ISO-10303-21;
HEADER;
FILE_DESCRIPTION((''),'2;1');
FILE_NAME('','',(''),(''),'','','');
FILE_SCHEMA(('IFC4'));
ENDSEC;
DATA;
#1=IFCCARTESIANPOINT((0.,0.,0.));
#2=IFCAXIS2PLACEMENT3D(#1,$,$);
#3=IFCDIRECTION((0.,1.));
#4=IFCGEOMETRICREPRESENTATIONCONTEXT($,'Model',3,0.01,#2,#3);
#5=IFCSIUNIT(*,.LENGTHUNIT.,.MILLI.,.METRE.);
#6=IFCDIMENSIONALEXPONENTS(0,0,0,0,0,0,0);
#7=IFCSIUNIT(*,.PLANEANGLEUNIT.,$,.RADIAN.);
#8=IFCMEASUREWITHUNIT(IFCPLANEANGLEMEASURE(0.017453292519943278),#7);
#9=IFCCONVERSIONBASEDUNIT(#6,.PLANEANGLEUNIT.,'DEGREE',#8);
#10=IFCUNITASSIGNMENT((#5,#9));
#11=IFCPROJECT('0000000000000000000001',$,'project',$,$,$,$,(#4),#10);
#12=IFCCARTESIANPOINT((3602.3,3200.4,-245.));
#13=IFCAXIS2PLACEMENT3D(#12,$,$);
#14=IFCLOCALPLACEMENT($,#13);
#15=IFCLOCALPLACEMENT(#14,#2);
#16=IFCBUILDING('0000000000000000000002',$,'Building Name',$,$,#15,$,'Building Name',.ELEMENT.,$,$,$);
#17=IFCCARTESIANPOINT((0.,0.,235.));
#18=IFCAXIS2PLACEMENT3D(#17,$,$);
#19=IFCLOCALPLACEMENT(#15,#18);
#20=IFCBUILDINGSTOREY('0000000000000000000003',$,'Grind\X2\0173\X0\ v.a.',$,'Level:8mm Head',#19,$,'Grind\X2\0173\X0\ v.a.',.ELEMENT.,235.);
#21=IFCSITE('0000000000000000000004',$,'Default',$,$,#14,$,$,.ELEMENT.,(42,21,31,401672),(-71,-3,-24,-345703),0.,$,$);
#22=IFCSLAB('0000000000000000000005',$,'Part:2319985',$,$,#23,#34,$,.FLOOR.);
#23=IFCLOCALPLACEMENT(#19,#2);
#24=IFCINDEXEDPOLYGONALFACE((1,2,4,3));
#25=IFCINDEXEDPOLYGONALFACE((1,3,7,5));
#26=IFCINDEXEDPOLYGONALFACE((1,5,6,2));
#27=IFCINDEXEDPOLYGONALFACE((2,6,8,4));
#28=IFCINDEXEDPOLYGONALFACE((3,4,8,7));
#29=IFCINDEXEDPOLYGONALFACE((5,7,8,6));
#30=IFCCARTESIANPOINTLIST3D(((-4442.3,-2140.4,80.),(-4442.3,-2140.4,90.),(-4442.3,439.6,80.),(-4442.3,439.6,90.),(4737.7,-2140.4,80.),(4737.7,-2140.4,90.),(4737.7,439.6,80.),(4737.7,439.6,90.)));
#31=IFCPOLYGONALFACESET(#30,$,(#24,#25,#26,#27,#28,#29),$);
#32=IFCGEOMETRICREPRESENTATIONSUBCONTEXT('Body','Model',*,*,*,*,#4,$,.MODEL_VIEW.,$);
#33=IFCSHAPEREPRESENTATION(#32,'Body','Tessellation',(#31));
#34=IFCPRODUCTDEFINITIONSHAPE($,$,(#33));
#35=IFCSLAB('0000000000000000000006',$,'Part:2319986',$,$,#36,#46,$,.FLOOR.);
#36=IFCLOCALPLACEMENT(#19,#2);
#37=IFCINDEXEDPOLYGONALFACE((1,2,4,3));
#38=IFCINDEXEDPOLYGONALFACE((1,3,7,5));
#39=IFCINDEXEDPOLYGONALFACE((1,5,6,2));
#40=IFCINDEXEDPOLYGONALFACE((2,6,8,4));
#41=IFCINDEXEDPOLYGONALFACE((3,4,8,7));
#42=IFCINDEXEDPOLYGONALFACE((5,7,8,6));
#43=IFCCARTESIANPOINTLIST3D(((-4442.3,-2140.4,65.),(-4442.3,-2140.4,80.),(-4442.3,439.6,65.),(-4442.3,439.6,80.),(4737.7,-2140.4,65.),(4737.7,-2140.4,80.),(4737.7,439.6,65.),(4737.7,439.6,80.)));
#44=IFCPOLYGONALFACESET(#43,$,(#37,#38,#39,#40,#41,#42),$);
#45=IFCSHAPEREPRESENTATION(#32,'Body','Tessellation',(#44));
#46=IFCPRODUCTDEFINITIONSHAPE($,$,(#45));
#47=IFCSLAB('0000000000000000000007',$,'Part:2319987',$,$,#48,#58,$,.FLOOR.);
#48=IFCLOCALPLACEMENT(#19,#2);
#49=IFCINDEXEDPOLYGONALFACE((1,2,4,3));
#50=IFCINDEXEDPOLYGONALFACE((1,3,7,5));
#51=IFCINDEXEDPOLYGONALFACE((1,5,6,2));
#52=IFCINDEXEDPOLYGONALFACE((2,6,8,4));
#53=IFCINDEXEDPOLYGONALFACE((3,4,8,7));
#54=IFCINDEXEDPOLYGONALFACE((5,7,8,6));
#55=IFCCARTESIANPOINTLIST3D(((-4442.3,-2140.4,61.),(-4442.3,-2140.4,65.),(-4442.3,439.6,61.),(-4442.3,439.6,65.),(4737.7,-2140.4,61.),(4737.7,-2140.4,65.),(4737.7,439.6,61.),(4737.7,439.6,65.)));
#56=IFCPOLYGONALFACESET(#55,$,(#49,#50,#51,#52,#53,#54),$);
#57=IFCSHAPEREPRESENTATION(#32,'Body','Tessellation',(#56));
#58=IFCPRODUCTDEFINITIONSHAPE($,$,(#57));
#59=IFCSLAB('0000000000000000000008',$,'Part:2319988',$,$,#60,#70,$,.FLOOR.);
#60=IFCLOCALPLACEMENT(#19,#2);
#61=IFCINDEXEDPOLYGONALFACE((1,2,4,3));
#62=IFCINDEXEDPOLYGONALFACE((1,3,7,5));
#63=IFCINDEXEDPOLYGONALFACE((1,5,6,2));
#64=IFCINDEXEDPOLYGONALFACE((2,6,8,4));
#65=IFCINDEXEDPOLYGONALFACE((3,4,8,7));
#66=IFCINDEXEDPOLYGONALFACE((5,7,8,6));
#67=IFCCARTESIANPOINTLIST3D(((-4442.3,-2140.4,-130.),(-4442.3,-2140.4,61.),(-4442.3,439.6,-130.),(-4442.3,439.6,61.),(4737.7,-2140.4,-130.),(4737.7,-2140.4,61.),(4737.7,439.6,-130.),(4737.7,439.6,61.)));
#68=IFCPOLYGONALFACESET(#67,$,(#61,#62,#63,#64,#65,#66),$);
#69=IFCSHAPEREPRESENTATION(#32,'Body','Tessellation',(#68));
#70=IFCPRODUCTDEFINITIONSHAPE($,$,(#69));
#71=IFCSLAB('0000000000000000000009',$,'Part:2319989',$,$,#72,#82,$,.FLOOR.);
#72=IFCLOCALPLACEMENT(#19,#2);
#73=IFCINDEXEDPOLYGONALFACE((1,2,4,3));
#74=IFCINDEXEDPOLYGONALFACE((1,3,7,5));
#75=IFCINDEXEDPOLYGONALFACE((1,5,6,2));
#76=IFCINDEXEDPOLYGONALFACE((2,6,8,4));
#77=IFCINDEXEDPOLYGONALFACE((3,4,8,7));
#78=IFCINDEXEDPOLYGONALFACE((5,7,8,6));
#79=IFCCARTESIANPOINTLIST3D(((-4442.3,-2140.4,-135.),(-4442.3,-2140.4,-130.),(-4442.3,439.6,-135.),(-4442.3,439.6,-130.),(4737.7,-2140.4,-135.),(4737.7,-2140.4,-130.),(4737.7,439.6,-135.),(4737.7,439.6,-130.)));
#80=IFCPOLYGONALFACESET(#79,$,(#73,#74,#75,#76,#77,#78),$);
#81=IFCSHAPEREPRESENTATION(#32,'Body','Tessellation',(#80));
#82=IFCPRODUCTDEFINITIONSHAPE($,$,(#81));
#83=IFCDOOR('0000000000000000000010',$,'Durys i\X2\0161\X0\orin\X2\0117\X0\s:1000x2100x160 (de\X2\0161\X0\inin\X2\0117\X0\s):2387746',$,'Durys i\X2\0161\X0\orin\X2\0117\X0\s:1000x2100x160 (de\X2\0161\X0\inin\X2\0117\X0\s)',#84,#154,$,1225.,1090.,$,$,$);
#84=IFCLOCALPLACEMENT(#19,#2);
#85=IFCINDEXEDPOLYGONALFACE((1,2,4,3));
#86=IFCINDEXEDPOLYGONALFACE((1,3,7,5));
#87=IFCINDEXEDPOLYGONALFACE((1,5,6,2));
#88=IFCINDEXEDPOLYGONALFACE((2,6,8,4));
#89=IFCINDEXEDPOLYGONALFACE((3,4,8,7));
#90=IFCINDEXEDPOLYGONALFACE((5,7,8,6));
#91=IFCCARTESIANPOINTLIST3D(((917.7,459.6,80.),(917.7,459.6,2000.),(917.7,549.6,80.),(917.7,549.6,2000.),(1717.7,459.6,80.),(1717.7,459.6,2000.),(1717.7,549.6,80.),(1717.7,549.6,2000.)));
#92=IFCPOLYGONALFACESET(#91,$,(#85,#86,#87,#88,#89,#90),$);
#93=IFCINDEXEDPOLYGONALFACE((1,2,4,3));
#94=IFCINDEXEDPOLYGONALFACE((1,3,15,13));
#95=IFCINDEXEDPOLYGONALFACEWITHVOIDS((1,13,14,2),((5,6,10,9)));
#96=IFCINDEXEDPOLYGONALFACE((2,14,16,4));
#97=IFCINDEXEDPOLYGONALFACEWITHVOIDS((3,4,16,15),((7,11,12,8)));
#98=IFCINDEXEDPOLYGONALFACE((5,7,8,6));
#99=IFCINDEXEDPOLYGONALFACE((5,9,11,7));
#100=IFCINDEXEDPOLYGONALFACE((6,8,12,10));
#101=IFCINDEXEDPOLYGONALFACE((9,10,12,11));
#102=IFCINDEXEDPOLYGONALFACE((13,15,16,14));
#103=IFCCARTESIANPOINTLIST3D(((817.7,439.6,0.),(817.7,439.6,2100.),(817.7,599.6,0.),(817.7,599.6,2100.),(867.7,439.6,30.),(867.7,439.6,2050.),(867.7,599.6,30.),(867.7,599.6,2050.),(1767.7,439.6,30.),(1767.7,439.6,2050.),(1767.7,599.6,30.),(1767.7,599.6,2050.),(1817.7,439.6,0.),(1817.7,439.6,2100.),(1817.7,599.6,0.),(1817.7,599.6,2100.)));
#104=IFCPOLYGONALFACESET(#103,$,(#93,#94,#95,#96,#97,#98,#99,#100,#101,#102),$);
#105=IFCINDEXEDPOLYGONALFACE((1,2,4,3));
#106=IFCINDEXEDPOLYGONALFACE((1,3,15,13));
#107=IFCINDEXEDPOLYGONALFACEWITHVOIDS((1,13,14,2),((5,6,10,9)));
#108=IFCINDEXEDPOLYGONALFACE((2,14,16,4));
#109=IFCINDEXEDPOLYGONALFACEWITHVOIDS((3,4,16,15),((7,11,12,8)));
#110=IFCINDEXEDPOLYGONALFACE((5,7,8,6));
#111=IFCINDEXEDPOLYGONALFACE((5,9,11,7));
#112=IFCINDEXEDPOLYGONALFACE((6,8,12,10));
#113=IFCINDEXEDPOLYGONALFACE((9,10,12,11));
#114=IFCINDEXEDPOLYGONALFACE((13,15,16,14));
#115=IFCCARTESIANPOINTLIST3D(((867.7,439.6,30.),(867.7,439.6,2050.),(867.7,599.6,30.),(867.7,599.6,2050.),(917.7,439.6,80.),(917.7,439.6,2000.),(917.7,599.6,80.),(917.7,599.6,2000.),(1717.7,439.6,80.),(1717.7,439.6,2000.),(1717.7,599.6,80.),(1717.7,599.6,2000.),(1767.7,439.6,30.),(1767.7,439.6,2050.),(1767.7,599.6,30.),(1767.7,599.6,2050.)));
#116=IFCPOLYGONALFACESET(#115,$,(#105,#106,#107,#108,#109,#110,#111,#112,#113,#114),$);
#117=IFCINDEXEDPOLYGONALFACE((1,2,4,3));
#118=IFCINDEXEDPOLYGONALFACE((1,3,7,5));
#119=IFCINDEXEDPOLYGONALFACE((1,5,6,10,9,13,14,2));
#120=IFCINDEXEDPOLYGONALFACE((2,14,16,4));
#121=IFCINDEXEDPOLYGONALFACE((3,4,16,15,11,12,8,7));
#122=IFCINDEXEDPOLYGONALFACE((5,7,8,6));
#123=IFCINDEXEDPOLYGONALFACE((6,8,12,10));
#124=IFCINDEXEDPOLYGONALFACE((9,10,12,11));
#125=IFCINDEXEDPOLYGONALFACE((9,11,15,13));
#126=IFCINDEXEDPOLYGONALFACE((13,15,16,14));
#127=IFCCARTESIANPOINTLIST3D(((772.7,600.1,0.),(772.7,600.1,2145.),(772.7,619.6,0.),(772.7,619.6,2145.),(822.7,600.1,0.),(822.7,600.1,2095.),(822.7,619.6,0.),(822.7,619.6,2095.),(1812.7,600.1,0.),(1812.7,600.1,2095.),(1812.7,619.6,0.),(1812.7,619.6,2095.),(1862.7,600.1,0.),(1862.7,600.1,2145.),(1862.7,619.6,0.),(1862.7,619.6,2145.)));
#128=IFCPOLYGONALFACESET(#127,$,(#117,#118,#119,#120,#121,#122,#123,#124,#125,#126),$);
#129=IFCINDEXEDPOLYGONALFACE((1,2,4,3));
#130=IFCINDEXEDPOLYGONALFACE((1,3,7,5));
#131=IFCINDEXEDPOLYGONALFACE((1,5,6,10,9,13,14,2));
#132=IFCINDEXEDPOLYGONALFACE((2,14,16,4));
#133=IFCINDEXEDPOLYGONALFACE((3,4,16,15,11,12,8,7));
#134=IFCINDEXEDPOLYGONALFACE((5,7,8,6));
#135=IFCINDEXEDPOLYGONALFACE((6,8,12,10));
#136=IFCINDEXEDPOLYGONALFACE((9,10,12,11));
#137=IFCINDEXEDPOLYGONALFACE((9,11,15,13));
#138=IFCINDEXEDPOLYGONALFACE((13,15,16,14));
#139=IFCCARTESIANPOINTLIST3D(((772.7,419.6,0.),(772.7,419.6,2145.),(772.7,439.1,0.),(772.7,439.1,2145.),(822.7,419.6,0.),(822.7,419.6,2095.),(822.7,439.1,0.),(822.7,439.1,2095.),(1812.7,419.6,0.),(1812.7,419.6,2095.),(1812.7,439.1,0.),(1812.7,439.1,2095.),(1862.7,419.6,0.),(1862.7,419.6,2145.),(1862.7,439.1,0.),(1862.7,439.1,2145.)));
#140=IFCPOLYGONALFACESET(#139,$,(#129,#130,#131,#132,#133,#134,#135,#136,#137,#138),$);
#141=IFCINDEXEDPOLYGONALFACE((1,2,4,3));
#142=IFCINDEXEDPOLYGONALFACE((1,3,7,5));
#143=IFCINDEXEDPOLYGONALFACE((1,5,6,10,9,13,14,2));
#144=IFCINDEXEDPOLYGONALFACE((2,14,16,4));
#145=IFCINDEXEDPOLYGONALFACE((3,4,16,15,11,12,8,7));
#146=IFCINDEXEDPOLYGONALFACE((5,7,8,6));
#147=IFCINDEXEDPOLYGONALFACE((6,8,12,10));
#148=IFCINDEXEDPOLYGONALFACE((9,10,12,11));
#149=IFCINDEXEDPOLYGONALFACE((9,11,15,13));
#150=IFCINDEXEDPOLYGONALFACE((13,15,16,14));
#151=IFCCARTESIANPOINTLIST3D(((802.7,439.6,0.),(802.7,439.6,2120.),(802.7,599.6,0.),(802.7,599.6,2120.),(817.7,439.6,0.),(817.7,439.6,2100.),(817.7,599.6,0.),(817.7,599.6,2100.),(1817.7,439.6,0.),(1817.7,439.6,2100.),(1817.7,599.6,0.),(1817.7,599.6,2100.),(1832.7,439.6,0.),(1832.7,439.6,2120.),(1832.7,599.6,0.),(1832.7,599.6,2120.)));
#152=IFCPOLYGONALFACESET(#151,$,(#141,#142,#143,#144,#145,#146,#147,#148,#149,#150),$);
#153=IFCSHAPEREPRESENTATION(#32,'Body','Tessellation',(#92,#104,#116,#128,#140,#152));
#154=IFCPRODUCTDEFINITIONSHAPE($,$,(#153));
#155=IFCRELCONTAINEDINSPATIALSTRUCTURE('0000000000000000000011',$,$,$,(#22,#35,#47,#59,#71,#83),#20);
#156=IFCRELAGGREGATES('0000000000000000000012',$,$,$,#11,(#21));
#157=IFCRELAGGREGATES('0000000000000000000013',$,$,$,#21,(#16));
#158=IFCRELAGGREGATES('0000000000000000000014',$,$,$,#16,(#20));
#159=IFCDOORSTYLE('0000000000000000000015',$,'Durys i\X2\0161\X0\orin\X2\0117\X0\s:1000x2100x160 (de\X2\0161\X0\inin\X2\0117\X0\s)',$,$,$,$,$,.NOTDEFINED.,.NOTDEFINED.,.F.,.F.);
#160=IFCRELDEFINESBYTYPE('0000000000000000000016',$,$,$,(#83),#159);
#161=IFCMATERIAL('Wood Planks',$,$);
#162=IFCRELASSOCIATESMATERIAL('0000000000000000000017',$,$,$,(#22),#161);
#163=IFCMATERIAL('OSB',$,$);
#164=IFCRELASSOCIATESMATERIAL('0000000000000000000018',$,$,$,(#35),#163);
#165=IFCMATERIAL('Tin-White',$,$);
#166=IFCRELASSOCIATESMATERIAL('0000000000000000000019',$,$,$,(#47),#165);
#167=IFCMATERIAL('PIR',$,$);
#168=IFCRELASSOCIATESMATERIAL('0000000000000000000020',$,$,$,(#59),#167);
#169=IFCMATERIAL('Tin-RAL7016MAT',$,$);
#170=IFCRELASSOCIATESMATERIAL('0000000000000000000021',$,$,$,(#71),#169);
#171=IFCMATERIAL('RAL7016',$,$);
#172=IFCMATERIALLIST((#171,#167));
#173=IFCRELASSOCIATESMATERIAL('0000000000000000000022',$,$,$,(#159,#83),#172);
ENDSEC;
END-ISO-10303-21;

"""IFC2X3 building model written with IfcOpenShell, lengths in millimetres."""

from ifc_helpers import new_model, entity, si_unit, converted_unit, direction, frame, frame_2d, origin, origin_2d_with_axis, place, context, subcontext, project, spatial, polyline, rectangle, outline, extrude, source, transform, mapped, material, material_list, type_object, type_shapes, element, save


model = new_model("IFC2X3")

# Units and contexts
model_context = context("Model", 3, precision=0.01, world=origin(), true_north=direction((0.0, 1.0)))
body_context = subcontext(model_context, "Body", "Model", "MODEL_VIEW")
ifc_project = project(units=[si_unit("LENGTHUNIT", "METRE", prefix="MILLI"), converted_unit("PLANEANGLEUNIT", "DEGREE", entity("IfcPlaneAngleMeasure", 0.017453292519943278), si_unit("PLANEANGLEUNIT", "RADIAN"), dimensions=[0, 0, 0, 0, 0, 0, 0])], contexts=[model_context])

# Site, building, storey
site_placement = place(None, frame((3602.3, 3200.4, -245.0)))
site = spatial("IfcSite", under=ifc_project, at=site_placement, Name="Default", CompositionType="ELEMENT", RefLatitude=(42, 21, 31, 401672), RefLongitude=(-71, -3, -24, -345703), RefElevation=0.0)
building_placement = place(site_placement, origin())
building = spatial("IfcBuilding", under=site, at=building_placement, Name="Building Name", LongName="Building Name", CompositionType="ELEMENT")
storey_placement = place(building_placement, frame((0.0, 0.0, 235.0)))
storey = spatial("IfcBuildingStorey", under=building, at=storey_placement, Name="Grindų v.a.", ObjectType="Level:8mm Head", LongName="Grindų v.a.", CompositionType="ELEMENT", Elevation=235.0)

# Slabs
ifc_material_1 = material(Name="Wood Planks")
slab_1_placement = place(storey_placement, frame((0.0, 0.0, 80.0)))
element("IfcSlab", 1, at=slab_1_placement, inside=storey, material=ifc_material_1, Name="Part:2319985", PredefinedType="FLOOR", context=body_context, shape_type="SweptSolid", body=[
    extrude(rectangle(XDim=2580.0, YDim=9180.0, at=frame_2d((0.0, 0.0), x_axis=(1.0, 0.0))), frame((147.7, -850.4, 0.0), z_axis=(0.0, 0.0, 1.0), x_axis=(0.0, -1.0, 0.0)), (0.0, 0.0, 1.0), 10.0),
])
ifc_material_2 = material(Name="OSB")
slab_2_placement = place(storey_placement, frame((0.0, 0.0, 65.0)))
element("IfcSlab", 2, at=slab_2_placement, inside=storey, material=ifc_material_2, Name="Part:2319986", PredefinedType="FLOOR", context=body_context, shape_type="SweptSolid", body=[
    extrude(rectangle(XDim=2580.0, YDim=9180.0, at=frame_2d((0.0, 0.0), x_axis=(1.0, 0.0))), frame((147.7, -850.4, 0.0), z_axis=(0.0, 0.0, 1.0), x_axis=(0.0, -1.0, 0.0)), (0.0, 0.0, 1.0), 15.0),
])
ifc_material_3 = material(Name="Tin-White")
slab_3_placement = place(storey_placement, frame((0.0, 0.0, 61.0)))
element("IfcSlab", 3, at=slab_3_placement, inside=storey, material=ifc_material_3, Name="Part:2319987", PredefinedType="FLOOR", context=body_context, shape_type="SweptSolid", body=[
    extrude(rectangle(XDim=2580.0, YDim=9180.0, at=frame_2d((0.0, 0.0), x_axis=(1.0, 0.0))), frame((147.7, -850.4, 0.0), z_axis=(0.0, 0.0, 1.0), x_axis=(0.0, -1.0, 0.0)), (0.0, 0.0, 1.0), 4.0),
])
ifc_material_4 = material(Name="PIR")
slab_4_placement = place(storey_placement, frame((0.0, 0.0, -130.0)))
element("IfcSlab", 4, at=slab_4_placement, inside=storey, material=ifc_material_4, Name="Part:2319988", PredefinedType="FLOOR", context=body_context, shape_type="SweptSolid", body=[
    extrude(rectangle(XDim=2580.0, YDim=9180.0, at=frame_2d((0.0, 0.0), x_axis=(1.0, 0.0))), frame((147.7, -850.4, 0.0), z_axis=(0.0, 0.0, 1.0), x_axis=(0.0, -1.0, 0.0)), (0.0, 0.0, 1.0), 191.0),
])
ifc_material_5 = material(Name="Tin-RAL7016MAT")
slab_5_placement = place(storey_placement, frame((0.0, 0.0, -135.0)))
element("IfcSlab", 5, at=slab_5_placement, inside=storey, material=ifc_material_5, Name="Part:2319989", PredefinedType="FLOOR", context=body_context, shape_type="SweptSolid", body=[
    extrude(rectangle(XDim=2580.0, YDim=9180.0, at=origin_2d_with_axis()), frame((147.7, -850.4, 0.0), z_axis=(0.0, 0.0, 1.0), x_axis=(0.0, -1.0, 0.0)), (0.0, 0.0, 1.0), 5.0),
])

# Door
ifc_material_6 = material(Name="RAL7016")
ifc_material_list_1 = material_list([ifc_material_6, ifc_material_4])
door_style_1 = type_object("IfcDoorStyle", Name="Durys išorinės:1000x2100x160 (dešininės)", ConstructionType="NOTDEFINED", OperationType="NOTDEFINED", ParameterTakesPrecedence=False, Sizeable=False, material=ifc_material_list_1)
shared_shape_1 = source(origin(), body_context, "Body", "SweptSolid", [
    extrude(rectangle(XDim=90.0, YDim=800.0, at=frame_2d((0.0, 0.0), x_axis=(1.0, 0.0))), frame((0.0, 95.0, 80.0), z_axis=(0.0, 0.0, 1.0), x_axis=(0.0, 1.0, 0.0)), (0.0, 0.0, 1.0), 1920.0),
    extrude(outline(polyline([(-500.0, -1050.0), (500.0, -1050.0), (500.0, 1050.0), (-500.0, 1050.0), (-500.0, -1050.0)]), holes=[polyline([(-450.0, -1000.0), (-450.0, 1020.0), (450.0, 1020.0), (450.0, -1000.0), (-450.0, -1000.0)])]), frame((0.0, 0.0, 1050.0), z_axis=(0.0, 1.0, 0.0), x_axis=(1.0, 0.0, 0.0)), (0.0, 0.0, 1.0), 160.0),
    extrude(outline(polyline([(-450.0, -1010.0), (450.0, -1010.0), (450.0, 1010.0), (-450.0, 1010.0), (-450.0, -1010.0)]), holes=[polyline([(-400.0, -960.0), (-400.0, 960.0), (400.0, 960.0), (400.0, -960.0), (-400.0, -960.0)])]), frame((0.0, 0.0, 1040.0), z_axis=(0.0, 1.0, 0.0), x_axis=(1.0, 0.0, 0.0)), (0.0, 0.0, 1.0), 160.0),
    extrude(outline(polyline([(-545.0, -1085.0), (545.0, -1085.0), (545.0, 1060.0), (495.0, 1060.0), (495.0, -1035.0), (-495.0, -1035.0), (-495.0, 1060.0), (-545.0, 1060.0), (-545.0, -1085.0)])), frame((0.0, -20.0, 1060.0), z_axis=(0.0, 1.0, 0.0), x_axis=(1.0, 0.0, 0.0)), (0.0, 0.0, 1.0), 19.5),
    extrude(outline(polyline([(-545.0, -1085.0), (545.0, -1085.0), (545.0, 1060.0), (495.0, 1060.0), (495.0, -1035.0), (-495.0, -1035.0), (-495.0, 1060.0), (-545.0, 1060.0), (-545.0, -1085.0)])), frame((0.0, 160.5, 1060.0), z_axis=(0.0, 1.0, 0.0), x_axis=(1.0, 0.0, 0.0)), (0.0, 0.0, 1.0), 19.5),
    extrude(outline(polyline([(-1055.0, -515.0), (1065.0, -515.0), (1065.0, 515.0), (-1055.0, 515.0), (-1055.0, 500.0), (1045.0, 500.0), (1045.0, -500.0), (-1055.0, -500.0), (-1055.0, -515.0)])), frame((0.0, 0.0, 1055.0), z_axis=(0.0, 1.0, 0.0), x_axis=(0.0, 0.0, 1.0)), (0.0, 0.0, 1.0), 160.0),
])
type_shapes(door_style_1, [shared_shape_1])
door_1_placement = place(storey_placement, frame((1317.7, 599.6, 0.0), z_axis=(0.0, 0.0, 1.0), x_axis=(-1.0, 0.0, 0.0)))
element("IfcDoor", 6, at=door_1_placement, inside=storey, type_object=door_style_1, material=ifc_material_list_1, Name="Durys išorinės:1000x2100x160 (dešininės):2387746", ObjectType="Durys išorinės:1000x2100x160 (dešininės)", OverallHeight=1225.0, OverallWidth=1090.0, context=body_context, shape_type="MappedRepresentation", body=[
    mapped(shared_shape_1, transform((0.0, 0.0, 0.0), scale=1.0)),
])

save(model, "model.ifc")
